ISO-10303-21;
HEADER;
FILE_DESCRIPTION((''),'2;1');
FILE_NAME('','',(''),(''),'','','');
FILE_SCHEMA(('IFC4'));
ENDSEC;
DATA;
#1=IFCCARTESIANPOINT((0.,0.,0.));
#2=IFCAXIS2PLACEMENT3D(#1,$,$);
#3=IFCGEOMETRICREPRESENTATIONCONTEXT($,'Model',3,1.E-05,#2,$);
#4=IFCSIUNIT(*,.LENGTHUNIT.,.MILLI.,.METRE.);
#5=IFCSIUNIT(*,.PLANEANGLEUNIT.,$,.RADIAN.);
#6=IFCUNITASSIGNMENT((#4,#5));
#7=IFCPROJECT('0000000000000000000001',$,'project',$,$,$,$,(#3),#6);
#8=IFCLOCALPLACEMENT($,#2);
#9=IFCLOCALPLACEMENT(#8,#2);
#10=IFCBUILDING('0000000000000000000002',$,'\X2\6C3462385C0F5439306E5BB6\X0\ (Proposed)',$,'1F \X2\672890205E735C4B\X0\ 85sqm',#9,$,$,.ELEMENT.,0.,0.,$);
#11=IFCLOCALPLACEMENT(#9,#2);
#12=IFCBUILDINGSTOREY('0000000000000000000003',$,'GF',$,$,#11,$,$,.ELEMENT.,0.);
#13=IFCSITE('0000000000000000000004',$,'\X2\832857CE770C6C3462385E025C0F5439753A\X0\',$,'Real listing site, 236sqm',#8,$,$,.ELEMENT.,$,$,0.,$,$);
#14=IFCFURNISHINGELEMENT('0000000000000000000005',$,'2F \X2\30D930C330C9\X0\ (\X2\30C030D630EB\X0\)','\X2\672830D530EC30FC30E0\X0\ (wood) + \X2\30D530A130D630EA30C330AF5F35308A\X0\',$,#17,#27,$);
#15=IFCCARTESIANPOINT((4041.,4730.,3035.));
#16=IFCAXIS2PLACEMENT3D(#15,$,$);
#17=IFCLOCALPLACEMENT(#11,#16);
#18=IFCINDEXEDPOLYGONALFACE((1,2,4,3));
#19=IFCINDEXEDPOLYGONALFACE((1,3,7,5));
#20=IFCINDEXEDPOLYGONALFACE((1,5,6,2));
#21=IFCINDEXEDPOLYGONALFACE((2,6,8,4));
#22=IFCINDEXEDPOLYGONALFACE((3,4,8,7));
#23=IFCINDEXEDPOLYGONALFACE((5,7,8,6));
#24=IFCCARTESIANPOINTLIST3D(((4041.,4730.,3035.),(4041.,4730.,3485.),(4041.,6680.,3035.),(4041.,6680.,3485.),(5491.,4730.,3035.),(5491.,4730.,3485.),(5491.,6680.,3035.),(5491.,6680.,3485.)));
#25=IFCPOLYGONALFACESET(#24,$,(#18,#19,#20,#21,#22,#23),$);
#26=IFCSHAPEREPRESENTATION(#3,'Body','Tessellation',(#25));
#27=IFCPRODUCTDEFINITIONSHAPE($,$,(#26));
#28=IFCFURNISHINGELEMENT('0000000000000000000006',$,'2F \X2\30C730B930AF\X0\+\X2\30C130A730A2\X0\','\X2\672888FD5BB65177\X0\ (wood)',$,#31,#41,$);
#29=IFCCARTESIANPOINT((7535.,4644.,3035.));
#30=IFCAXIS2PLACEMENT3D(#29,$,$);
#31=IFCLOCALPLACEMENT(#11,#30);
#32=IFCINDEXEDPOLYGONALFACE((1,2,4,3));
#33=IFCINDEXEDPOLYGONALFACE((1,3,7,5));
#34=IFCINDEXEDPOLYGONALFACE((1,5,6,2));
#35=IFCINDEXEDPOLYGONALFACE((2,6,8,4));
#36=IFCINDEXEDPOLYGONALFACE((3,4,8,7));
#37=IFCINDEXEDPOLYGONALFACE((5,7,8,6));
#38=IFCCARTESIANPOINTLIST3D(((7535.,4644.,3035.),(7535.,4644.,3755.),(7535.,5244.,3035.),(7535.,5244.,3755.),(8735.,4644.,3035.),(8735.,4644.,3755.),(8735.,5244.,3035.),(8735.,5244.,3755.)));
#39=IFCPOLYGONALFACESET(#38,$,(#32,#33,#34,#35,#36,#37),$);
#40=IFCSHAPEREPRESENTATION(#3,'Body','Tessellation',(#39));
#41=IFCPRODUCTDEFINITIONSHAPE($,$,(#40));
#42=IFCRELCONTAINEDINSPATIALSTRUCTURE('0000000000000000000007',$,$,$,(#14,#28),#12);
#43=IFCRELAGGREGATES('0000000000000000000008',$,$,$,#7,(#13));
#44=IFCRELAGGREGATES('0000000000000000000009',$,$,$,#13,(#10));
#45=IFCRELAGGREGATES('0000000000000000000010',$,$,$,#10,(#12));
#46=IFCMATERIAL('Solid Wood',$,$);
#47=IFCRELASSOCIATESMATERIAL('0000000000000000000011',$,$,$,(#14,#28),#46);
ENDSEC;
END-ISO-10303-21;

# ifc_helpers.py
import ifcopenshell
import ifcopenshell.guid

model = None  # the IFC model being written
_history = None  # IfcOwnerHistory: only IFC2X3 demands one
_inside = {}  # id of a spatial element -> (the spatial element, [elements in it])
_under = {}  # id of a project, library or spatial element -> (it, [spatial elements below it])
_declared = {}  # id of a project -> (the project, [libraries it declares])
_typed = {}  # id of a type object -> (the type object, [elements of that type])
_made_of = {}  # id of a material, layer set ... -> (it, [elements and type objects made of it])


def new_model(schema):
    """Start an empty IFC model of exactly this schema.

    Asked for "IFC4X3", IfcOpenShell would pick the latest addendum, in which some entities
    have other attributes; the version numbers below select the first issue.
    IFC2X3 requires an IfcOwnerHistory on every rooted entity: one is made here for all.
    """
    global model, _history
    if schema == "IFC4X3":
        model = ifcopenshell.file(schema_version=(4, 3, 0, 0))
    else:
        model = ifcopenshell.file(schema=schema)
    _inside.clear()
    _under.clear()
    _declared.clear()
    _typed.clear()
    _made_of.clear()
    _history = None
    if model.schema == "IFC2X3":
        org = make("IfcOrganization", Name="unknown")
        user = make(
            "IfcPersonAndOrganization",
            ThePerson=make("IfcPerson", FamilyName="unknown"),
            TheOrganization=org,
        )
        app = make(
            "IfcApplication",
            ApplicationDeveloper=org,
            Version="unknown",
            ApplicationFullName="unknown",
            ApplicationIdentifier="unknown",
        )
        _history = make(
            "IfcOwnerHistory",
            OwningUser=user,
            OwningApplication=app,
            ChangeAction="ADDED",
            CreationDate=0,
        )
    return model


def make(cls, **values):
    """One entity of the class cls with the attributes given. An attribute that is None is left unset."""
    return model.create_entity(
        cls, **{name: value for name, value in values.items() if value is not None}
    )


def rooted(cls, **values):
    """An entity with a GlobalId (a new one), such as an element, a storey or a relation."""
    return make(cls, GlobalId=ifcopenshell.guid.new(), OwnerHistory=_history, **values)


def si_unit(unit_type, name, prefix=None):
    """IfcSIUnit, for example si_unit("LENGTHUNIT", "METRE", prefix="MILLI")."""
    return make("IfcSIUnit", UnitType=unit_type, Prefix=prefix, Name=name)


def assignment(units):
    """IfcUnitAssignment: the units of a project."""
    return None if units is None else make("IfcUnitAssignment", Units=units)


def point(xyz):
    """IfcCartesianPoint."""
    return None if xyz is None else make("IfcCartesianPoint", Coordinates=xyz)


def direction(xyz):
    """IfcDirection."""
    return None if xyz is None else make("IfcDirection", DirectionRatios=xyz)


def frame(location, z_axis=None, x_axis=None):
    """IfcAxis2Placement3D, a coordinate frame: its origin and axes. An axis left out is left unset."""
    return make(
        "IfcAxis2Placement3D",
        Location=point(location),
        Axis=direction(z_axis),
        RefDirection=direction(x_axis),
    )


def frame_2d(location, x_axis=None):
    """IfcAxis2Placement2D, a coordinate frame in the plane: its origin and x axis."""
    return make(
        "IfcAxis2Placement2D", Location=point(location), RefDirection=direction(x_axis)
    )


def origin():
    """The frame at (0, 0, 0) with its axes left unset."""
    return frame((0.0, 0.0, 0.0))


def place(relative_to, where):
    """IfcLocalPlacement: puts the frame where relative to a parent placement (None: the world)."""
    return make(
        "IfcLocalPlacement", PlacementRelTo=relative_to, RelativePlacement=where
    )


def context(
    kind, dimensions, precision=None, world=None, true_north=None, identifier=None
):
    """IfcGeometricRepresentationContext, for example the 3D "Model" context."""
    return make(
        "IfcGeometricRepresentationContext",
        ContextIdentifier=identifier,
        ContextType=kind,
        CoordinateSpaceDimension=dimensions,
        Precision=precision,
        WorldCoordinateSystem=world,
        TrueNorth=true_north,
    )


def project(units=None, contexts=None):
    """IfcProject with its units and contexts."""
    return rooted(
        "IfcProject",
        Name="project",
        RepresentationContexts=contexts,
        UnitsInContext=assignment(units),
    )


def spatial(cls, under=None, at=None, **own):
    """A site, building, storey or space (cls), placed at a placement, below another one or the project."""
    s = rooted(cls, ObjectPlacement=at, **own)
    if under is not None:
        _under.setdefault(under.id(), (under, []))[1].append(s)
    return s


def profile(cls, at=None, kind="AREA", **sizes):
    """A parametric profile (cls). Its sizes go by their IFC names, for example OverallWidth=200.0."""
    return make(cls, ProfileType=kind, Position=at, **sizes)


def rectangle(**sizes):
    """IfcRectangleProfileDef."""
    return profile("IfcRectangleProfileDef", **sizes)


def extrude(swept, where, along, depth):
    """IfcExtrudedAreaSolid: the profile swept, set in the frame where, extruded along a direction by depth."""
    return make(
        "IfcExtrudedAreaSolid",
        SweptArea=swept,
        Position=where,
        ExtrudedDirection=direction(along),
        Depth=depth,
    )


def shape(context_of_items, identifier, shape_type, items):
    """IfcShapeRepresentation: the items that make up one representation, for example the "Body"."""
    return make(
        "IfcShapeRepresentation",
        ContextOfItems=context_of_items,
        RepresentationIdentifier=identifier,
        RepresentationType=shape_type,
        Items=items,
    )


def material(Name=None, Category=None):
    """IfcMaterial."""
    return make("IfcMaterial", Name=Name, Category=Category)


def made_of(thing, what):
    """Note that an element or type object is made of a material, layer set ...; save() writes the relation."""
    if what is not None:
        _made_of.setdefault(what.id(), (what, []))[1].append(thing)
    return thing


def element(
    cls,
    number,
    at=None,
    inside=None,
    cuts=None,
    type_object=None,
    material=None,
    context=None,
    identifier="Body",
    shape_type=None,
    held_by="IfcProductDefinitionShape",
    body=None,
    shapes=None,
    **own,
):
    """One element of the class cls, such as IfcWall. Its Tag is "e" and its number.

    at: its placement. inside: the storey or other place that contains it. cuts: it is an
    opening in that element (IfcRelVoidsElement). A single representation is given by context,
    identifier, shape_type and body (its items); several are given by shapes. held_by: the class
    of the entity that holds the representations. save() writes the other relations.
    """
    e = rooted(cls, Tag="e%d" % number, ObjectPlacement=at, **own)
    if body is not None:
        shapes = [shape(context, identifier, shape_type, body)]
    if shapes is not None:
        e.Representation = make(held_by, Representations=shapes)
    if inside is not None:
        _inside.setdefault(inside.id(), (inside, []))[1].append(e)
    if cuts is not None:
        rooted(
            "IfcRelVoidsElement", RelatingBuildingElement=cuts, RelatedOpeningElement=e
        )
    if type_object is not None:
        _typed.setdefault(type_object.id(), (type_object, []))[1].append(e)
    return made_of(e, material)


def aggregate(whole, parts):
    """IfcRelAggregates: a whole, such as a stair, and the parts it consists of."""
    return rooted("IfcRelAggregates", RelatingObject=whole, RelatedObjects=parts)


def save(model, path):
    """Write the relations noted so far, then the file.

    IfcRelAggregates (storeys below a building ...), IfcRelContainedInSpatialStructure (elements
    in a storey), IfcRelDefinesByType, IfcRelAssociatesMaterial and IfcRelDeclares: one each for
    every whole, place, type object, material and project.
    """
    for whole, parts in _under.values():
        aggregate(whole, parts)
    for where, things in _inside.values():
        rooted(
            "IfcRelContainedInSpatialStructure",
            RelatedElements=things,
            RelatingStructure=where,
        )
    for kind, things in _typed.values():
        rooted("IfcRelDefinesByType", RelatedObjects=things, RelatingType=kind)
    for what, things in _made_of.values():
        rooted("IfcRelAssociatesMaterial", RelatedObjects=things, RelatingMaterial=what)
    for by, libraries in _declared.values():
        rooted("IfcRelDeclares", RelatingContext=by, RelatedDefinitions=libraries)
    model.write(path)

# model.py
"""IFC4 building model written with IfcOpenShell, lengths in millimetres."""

from ifc_helpers import new_model, si_unit, frame, frame_2d, origin, place, context, project, spatial, rectangle, extrude, material, element, save


model = new_model("IFC4")

# Units and contexts
model_context = context("Model", 3, precision=1e-05, world=origin())
ifc_project = project(units=[si_unit("LENGTHUNIT", "METRE", prefix="MILLI"), si_unit("PLANEANGLEUNIT", "RADIAN")], contexts=[model_context])

# Site, building, storey
site_placement = place(None, origin())
site = spatial("IfcSite", under=ifc_project, at=site_placement, Name="茨城県水戸市小吹町", ObjectType="Real listing site, 236sqm", CompositionType="ELEMENT", RefElevation=0.0)
building_placement = place(site_placement, origin())
building = spatial("IfcBuilding", under=site, at=building_placement, Name="水戸小吹の家 (Proposed)", ObjectType="1F 木造平屋 85sqm", CompositionType="ELEMENT", ElevationOfRefHeight=0.0, ElevationOfTerrain=0.0)
storey_placement = place(building_placement, origin())
storey = spatial("IfcBuildingStorey", under=building, at=storey_placement, Name="GF", CompositionType="ELEMENT", Elevation=0.0)

# Shared definitions
ifc_material_1 = material(Name="Solid Wood")

# Furnishing elements
furnishing_1_placement = place(storey_placement, frame((4041.0, 4730.0, 3035.0)))
element("IfcFurnishingElement", 1, at=furnishing_1_placement, inside=storey, material=ifc_material_1, Name="2F ベッド (ダブル)", Description="木フレーム (wood) + ファブリック張り", context=model_context, shape_type="SweptSolid", body=[
    extrude(rectangle(XDim=1450.0, YDim=1950.0, at=frame_2d((725.0, 975.0))), frame((4041.0, 4730.0, 3035.0)), (0.0, 0.0, 1.0), 450.0),
])
furnishing_2_placement = place(storey_placement, frame((7535.0, 4644.0, 3035.0)))
element("IfcFurnishingElement", 2, at=furnishing_2_placement, inside=storey, material=ifc_material_1, Name="2F デスク+チェア", Description="木製家具 (wood)", context=model_context, shape_type="SweptSolid", body=[
    extrude(rectangle(XDim=1200.0, YDim=600.0, at=frame_2d((600.0, 300.0))), frame((7535.0, 4644.0, 3035.0)), (0.0, 0.0, 1.0), 720.0),
])

save(model, "model.ifc")
